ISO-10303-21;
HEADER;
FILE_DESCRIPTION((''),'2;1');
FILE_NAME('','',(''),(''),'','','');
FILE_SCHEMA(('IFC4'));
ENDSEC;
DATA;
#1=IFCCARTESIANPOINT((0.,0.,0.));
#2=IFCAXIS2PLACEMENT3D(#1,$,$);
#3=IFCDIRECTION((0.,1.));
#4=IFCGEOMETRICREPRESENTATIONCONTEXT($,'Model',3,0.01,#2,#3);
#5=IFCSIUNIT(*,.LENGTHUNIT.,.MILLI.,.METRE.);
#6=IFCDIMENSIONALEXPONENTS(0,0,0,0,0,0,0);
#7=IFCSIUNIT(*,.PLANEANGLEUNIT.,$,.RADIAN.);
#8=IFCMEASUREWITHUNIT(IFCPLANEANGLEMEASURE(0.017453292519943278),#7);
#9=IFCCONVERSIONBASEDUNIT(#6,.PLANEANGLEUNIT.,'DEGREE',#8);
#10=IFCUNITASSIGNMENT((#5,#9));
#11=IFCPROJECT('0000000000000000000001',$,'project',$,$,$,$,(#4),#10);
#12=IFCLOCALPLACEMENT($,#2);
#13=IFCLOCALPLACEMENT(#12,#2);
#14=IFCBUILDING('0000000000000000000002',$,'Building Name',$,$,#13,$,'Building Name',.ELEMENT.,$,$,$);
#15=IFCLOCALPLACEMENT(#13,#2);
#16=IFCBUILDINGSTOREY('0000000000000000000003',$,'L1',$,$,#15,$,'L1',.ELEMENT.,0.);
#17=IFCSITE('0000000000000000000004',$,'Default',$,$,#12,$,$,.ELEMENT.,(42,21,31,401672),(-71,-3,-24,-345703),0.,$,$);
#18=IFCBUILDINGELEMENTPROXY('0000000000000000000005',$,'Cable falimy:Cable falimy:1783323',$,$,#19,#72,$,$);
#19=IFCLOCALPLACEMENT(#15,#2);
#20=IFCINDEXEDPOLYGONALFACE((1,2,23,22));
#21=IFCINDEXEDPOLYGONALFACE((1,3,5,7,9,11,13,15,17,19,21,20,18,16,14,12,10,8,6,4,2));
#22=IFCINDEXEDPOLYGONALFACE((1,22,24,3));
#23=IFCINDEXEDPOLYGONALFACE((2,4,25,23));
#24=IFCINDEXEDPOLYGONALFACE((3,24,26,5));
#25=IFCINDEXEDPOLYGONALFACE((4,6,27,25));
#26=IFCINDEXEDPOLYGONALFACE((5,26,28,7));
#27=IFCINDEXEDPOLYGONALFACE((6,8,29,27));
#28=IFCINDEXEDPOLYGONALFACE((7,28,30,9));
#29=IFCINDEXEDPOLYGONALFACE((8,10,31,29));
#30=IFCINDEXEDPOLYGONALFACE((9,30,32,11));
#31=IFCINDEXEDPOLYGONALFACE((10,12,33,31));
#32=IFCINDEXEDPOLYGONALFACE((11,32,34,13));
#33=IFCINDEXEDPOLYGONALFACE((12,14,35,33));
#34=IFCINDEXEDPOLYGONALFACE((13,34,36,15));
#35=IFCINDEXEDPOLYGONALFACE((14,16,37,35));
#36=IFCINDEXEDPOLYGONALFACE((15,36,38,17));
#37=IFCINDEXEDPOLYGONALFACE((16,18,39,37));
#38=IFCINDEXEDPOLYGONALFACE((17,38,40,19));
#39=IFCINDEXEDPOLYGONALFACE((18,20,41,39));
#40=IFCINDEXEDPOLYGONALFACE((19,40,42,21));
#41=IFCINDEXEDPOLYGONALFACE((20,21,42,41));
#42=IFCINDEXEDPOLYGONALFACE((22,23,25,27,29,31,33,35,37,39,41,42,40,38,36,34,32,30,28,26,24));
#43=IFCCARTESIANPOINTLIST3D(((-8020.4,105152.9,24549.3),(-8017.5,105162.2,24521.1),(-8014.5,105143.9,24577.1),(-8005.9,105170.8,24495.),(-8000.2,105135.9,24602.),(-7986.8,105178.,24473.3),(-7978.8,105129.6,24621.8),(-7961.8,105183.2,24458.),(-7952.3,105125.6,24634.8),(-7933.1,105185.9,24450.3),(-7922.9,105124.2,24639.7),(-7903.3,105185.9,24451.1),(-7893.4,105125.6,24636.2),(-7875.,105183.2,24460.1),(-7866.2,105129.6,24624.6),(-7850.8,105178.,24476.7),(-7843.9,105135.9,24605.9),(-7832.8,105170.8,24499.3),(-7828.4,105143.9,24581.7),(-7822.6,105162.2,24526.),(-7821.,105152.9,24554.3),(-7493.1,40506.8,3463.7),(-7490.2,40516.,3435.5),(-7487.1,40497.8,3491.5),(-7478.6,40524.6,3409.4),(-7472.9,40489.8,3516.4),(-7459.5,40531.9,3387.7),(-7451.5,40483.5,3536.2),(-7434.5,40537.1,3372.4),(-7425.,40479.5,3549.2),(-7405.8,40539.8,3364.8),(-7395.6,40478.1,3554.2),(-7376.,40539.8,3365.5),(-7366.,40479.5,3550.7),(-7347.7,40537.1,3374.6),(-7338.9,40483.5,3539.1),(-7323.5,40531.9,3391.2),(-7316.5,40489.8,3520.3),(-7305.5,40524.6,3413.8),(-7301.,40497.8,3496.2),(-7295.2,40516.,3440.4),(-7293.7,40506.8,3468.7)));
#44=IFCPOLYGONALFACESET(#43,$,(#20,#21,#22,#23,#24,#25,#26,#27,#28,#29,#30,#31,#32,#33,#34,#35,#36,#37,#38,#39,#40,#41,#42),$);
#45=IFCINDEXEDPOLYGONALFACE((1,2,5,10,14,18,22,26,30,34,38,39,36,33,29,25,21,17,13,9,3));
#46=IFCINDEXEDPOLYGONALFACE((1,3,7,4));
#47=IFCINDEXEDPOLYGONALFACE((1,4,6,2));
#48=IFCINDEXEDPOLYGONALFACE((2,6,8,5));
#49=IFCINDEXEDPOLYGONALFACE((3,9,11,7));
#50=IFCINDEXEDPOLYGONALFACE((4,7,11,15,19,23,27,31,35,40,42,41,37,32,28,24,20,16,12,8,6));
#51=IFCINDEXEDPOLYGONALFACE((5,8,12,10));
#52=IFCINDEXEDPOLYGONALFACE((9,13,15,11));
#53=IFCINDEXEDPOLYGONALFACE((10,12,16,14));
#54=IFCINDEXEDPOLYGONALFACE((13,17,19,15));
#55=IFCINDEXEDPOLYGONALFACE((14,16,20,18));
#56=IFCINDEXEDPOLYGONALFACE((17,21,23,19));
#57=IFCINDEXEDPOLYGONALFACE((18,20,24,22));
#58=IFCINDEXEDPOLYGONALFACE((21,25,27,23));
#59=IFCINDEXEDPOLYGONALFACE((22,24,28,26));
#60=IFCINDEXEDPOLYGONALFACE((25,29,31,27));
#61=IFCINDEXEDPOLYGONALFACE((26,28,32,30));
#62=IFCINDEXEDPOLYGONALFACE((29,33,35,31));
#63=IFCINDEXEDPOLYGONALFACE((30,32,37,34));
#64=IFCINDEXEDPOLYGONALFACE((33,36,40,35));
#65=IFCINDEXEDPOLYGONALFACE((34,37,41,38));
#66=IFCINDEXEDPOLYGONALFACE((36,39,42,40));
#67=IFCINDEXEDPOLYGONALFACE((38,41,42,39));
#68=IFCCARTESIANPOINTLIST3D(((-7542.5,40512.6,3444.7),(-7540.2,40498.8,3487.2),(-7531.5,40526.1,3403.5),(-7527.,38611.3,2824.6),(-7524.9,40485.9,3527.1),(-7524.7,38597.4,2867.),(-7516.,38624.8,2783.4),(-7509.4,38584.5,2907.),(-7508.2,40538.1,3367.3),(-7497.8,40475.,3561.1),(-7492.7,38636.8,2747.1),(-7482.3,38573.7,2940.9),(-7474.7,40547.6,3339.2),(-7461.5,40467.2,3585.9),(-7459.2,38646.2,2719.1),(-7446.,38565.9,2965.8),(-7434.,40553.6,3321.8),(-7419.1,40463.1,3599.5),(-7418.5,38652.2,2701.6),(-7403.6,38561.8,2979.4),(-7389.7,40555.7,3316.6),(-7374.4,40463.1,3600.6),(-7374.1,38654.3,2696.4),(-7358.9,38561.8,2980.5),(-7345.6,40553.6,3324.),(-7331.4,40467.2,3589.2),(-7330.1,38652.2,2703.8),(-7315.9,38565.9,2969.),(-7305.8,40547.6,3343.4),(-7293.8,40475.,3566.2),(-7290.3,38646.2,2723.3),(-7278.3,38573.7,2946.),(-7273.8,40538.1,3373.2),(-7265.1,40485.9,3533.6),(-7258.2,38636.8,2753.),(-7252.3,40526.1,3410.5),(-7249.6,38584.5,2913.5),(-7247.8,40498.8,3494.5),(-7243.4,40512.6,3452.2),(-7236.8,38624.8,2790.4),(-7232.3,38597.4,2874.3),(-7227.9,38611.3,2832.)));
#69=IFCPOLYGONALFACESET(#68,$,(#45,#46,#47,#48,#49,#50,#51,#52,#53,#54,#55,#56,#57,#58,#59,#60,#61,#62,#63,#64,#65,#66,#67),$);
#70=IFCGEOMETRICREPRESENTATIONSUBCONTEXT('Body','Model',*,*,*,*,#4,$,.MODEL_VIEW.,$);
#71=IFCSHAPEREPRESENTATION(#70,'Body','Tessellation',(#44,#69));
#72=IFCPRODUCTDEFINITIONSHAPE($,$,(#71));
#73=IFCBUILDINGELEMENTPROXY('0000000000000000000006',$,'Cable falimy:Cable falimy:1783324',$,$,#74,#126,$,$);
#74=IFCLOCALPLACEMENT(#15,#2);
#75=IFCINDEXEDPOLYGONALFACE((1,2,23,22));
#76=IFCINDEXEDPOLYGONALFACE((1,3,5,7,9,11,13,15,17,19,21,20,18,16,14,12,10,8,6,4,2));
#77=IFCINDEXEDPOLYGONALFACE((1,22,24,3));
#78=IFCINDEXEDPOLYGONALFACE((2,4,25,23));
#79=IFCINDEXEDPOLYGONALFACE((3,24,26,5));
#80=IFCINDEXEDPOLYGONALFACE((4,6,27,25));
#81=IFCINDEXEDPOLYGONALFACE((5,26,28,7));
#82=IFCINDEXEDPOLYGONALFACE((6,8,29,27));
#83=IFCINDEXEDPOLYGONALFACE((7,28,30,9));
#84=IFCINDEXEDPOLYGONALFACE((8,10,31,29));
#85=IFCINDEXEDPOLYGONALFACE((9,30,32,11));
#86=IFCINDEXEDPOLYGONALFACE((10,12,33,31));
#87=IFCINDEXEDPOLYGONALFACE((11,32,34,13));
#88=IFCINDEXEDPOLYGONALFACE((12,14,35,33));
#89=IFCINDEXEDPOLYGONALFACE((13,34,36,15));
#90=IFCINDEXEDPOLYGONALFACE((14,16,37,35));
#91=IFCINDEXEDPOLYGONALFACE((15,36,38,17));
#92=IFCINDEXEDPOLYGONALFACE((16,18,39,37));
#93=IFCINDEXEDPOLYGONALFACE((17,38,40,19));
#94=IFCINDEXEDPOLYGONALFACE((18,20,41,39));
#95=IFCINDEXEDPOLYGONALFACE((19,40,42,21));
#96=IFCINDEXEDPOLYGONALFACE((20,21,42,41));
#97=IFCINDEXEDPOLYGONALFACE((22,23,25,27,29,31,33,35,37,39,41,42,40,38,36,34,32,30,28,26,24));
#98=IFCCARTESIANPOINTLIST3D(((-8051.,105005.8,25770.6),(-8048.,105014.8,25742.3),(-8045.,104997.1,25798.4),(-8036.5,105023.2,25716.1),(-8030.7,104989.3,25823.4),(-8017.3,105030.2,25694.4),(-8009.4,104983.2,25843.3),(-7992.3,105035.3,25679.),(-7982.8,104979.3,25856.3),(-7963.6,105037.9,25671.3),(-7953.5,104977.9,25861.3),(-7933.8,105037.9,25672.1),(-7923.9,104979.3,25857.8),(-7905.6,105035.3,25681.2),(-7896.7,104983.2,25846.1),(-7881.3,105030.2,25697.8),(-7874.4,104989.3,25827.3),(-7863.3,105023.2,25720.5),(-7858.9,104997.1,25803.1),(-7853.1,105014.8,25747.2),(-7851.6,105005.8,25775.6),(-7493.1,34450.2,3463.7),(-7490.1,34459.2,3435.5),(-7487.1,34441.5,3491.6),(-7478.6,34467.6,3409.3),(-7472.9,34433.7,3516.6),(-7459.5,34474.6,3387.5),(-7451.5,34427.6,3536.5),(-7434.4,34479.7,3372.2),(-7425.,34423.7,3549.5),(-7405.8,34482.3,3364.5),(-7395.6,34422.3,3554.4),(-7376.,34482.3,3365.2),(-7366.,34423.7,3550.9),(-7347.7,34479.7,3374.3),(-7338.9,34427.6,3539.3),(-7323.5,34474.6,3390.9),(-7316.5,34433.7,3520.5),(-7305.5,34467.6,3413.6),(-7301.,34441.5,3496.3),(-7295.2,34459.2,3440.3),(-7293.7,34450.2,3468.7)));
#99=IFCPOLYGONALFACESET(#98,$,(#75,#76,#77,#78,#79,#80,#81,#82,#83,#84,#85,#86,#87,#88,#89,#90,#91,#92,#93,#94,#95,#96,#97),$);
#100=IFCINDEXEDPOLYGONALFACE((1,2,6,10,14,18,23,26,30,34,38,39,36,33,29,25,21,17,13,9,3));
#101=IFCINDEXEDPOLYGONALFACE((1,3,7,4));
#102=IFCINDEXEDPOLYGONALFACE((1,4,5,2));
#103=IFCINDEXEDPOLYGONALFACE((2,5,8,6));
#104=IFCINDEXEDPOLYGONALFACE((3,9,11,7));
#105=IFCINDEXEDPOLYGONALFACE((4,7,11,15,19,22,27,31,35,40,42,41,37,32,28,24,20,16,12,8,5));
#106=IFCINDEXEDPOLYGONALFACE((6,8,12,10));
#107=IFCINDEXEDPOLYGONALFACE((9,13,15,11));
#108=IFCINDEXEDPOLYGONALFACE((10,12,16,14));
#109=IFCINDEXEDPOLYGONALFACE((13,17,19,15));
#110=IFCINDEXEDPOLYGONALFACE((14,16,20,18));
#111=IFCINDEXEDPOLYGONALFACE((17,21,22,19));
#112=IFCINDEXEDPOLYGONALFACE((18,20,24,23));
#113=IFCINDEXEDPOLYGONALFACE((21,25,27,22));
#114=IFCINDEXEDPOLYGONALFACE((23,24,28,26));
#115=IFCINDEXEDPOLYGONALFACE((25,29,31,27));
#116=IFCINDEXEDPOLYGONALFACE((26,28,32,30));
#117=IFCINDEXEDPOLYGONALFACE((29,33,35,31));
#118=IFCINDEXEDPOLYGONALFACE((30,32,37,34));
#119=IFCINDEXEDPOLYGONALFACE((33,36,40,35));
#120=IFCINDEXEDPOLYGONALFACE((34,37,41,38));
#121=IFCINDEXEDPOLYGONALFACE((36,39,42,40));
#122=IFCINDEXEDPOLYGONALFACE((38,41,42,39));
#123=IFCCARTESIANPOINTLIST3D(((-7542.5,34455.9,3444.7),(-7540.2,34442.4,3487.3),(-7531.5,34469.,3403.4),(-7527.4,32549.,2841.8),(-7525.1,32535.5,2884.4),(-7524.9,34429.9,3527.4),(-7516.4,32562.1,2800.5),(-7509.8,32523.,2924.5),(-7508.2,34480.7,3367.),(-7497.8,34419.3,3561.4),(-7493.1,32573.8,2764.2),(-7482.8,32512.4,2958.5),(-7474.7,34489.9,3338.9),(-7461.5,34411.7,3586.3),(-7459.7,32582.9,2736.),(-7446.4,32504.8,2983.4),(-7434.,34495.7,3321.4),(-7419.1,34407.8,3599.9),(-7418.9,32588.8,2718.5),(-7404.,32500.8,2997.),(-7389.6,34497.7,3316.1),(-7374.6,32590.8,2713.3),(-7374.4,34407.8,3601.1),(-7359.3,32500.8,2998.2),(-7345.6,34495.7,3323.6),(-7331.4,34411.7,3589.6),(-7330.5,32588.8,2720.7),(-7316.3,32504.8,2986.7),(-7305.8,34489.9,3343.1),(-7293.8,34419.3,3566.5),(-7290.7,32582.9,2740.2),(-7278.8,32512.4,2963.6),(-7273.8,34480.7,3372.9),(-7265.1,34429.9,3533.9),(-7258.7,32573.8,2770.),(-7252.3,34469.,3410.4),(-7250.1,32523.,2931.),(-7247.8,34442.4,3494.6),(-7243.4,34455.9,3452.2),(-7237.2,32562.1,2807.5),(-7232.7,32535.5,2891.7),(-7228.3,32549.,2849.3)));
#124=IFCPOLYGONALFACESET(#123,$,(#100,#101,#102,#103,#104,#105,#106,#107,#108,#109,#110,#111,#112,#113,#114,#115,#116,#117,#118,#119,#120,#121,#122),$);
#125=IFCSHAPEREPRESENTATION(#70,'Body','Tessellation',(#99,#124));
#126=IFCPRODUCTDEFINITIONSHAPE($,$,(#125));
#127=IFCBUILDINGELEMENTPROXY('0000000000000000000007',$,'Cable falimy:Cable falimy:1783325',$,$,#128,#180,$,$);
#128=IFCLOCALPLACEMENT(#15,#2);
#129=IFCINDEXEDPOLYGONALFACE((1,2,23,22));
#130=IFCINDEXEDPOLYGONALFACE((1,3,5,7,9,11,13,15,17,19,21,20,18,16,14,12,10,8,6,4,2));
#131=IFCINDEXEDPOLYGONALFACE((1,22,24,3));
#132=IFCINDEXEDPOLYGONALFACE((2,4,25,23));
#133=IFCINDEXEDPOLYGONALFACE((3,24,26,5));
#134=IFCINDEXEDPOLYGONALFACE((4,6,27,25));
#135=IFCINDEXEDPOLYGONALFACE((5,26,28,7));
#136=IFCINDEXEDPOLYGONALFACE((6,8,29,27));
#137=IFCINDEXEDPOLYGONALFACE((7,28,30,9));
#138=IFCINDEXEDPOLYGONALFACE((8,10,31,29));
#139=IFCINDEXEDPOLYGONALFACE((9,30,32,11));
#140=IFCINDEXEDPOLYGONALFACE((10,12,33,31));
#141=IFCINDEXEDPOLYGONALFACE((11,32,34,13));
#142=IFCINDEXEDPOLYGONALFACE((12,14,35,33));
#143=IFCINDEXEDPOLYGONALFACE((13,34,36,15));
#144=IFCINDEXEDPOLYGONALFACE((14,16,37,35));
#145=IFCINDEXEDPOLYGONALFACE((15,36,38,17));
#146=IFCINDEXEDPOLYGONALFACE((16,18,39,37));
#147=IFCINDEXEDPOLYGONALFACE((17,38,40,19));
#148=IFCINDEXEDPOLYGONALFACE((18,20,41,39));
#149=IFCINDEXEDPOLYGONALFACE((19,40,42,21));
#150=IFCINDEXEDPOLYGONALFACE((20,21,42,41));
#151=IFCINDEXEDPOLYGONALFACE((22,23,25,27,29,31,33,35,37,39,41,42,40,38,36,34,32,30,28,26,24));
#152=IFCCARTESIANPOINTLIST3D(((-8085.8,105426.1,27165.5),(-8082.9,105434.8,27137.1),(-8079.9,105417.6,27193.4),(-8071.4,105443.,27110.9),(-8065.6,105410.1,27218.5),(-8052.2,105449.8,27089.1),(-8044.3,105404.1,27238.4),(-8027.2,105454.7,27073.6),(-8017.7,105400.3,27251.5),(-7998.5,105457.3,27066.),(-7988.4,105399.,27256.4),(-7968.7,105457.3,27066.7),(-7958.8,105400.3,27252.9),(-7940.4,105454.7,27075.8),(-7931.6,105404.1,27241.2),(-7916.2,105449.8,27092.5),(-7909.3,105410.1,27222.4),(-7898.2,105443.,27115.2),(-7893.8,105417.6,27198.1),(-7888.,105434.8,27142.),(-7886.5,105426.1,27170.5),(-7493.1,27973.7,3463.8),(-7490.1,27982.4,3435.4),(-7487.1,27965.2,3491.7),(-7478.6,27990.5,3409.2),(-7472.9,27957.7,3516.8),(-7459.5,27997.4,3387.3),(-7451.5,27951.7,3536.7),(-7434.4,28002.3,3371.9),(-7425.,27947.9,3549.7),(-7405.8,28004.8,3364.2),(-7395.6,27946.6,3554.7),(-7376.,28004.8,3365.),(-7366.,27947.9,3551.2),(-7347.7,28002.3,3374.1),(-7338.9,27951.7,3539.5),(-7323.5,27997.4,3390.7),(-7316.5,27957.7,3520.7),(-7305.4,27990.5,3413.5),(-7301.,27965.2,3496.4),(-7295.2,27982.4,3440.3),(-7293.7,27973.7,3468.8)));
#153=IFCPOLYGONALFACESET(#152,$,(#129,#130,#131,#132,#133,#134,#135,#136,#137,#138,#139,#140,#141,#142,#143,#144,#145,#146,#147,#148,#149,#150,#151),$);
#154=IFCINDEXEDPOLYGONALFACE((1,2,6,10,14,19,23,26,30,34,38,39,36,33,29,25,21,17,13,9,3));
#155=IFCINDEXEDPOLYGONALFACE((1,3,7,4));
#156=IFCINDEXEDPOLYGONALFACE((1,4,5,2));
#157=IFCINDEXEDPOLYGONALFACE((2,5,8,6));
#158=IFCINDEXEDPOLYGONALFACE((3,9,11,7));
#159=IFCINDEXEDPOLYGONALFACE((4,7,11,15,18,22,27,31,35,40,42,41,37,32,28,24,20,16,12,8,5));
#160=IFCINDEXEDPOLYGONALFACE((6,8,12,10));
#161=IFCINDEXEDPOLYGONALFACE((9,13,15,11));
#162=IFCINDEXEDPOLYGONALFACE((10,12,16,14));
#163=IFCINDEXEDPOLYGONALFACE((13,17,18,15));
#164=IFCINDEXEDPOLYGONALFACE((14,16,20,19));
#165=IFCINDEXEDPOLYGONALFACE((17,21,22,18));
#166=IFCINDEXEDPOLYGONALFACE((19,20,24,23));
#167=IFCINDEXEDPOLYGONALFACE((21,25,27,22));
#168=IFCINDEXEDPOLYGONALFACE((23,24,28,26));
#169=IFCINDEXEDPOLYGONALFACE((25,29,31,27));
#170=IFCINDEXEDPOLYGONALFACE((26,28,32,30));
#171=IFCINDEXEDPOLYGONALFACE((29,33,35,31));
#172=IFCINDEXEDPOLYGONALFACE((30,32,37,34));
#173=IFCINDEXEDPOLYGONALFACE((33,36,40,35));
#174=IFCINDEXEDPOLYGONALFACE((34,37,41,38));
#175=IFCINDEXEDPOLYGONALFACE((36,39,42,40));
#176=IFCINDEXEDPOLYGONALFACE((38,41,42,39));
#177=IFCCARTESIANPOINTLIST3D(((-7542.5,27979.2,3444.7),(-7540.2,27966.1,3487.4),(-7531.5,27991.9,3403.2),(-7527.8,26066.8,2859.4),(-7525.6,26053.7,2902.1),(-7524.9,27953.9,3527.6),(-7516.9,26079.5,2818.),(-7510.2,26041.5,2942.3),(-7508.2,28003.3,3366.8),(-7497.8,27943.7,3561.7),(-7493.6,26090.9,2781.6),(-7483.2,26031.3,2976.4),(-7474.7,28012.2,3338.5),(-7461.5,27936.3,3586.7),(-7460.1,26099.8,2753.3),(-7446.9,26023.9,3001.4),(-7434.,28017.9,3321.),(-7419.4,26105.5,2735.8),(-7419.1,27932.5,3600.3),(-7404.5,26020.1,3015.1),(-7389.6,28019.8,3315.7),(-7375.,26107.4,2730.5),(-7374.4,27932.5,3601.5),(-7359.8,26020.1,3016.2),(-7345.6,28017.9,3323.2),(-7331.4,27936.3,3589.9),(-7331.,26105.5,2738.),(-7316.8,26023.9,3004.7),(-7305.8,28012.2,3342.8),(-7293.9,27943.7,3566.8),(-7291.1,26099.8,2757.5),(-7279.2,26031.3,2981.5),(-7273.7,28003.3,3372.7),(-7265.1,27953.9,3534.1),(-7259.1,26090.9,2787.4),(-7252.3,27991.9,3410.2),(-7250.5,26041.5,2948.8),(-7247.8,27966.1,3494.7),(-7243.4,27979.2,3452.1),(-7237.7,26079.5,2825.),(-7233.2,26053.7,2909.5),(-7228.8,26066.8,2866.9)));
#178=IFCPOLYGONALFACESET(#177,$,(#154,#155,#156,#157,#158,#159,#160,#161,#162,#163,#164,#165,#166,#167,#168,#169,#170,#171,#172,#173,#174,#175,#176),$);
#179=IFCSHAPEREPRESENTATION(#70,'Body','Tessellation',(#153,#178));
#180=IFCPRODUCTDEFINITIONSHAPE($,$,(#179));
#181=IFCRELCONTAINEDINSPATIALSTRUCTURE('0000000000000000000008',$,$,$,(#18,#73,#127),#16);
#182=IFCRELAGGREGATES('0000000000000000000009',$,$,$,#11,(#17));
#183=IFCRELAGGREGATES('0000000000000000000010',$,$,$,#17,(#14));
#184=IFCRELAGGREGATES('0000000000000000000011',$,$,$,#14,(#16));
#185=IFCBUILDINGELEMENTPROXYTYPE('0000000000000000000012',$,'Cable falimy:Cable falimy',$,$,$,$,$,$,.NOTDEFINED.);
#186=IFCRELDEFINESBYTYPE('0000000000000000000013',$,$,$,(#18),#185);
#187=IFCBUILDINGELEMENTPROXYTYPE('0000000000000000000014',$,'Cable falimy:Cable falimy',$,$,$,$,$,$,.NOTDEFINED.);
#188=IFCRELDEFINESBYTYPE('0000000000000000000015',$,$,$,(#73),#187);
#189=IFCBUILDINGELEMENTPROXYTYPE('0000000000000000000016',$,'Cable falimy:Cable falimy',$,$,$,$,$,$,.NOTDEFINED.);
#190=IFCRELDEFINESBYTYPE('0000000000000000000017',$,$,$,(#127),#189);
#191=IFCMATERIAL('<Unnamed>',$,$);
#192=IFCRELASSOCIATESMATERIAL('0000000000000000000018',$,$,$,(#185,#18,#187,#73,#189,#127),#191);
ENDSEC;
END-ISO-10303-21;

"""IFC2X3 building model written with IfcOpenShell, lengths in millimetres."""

from ifc_helpers import new_model, entity, si_unit, converted_unit, direction, frame, frame_2d, origin, place, context, subcontext, project, spatial, circle, extrude, source, transform, mapped, material, type_object, type_shapes, element, save


model = new_model("IFC2X3")

# Units and contexts
model_context = context("Model", 3, precision=0.01, world=origin(), true_north=direction((0.0, 1.0)))
body_context = subcontext(model_context, "Body", "Model", "MODEL_VIEW")
ifc_project = project(units=[si_unit("LENGTHUNIT", "METRE", prefix="MILLI"), converted_unit("PLANEANGLEUNIT", "DEGREE", entity("IfcPlaneAngleMeasure", 0.017453292519943278), si_unit("PLANEANGLEUNIT", "RADIAN"), dimensions=[0, 0, 0, 0, 0, 0, 0])], contexts=[model_context])

# Site, building, storey
site_placement = place(None, origin())
site = spatial("IfcSite", under=ifc_project, at=site_placement, Name="Default", CompositionType="ELEMENT", RefLatitude=(42, 21, 31, 401672), RefLongitude=(-71, -3, -24, -345703), RefElevation=0.0)
building_placement = place(site_placement, origin())
building = spatial("IfcBuilding", under=site, at=building_placement, Name="Building Name", LongName="Building Name", CompositionType="ELEMENT")
storey_placement = place(building_placement, origin())
storey = spatial("IfcBuildingStorey", under=building, at=storey_placement, Name="L1", LongName="L1", CompositionType="ELEMENT", Elevation=0.0)

# Shared definitions
ifc_material = material(Name="<Unnamed>")

# Building element proxies
building_element_proxy_type_1 = type_object("IfcBuildingElementProxyType", Name="Cable falimy:Cable falimy", PredefinedType="NOTDEFINED", material=ifc_material)
shared_shape_1 = source(origin(), body_context, "Body", "SweptSolid", [
    extrude(circle(Radius=100.0, at=frame_2d((0.0, 0.0), x_axis=(1.0, 0.0))), frame((0.0, 0.0, 0.0), z_axis=(0.950678, 0.0, 0.310179), x_axis=(-0.310179, 0.0, 0.950678)), (0.0, 0.0, 1.0), 68000.0),
    extrude(circle(Radius=150.0, at=frame_2d((0.0, 0.0), x_axis=(1.0, 0.0))), frame((-1901.4, 0.0, -620.4), z_axis=(0.950678, 0.0, 0.310179), x_axis=(0.310179, 0.0, -0.950678)), (0.0, 0.0, 1.0), 2000.0),
])
type_shapes(building_element_proxy_type_1, [shared_shape_1])
proxy_1_placement = place(storey_placement, frame((-7393.2, 40509.1, 3459.1), z_axis=(-0.025001, 0.0, 0.999687), x_axis=(0.0, 1.0, 0.0)))
element("IfcBuildingElementProxy", 1, at=proxy_1_placement, inside=storey, type_object=building_element_proxy_type_1, material=ifc_material, Name="Cable falimy:Cable falimy:1783323", context=body_context, shape_type="MappedRepresentation", body=[
    mapped(shared_shape_1, transform((0.0, 0.0, 0.0), scale=1.0)),
])
building_element_proxy_type_2 = type_object("IfcBuildingElementProxyType", Name="Cable falimy:Cable falimy", PredefinedType="NOTDEFINED", material=ifc_material)
shared_shape_2 = source(origin(), body_context, "Body", "SweptSolid", [
    extrude(circle(Radius=100.0, at=frame_2d((0.0, 0.0), x_axis=(1.0, 0.0))), frame((0.0, 0.0, 0.0), z_axis=(0.953454, 0.0, 0.301538), x_axis=(-0.301538, 0.0, 0.953454)), (0.0, 0.0, 1.0), 74000.0),
    extrude(circle(Radius=150.0, at=frame_2d((0.0, 0.0), x_axis=(1.0, 0.0))), frame((-1906.9, 0.0, -603.1), z_axis=(0.953454, 0.0, 0.301538), x_axis=(0.301538, 0.0, -0.953454)), (0.0, 0.0, 1.0), 2000.0),
])
type_shapes(building_element_proxy_type_2, [shared_shape_2])
proxy_2_placement = place(storey_placement, frame((-7393.2, 34452.5, 3459.1), z_axis=(-0.025001, 0.0, 0.999687), x_axis=(0.0, 1.0, 0.0)))
element("IfcBuildingElementProxy", 2, at=proxy_2_placement, inside=storey, type_object=building_element_proxy_type_2, material=ifc_material, Name="Cable falimy:Cable falimy:1783324", context=body_context, shape_type="MappedRepresentation", body=[
    mapped(shared_shape_2, transform((0.0, 0.0, 0.0), scale=1.0)),
])
building_element_proxy_type_3 = type_object("IfcBuildingElementProxyType", Name="Cable falimy:Cable falimy", PredefinedType="NOTDEFINED", material=ifc_material)
shared_shape_3 = source(origin(), body_context, "Body", "SweptSolid", [
    extrude(circle(Radius=100.0, at=frame_2d((0.0, 0.0), x_axis=(1.0, 0.0))), frame((0.0, 0.0, 0.0), z_axis=(0.956203, 0.0, 0.292706), x_axis=(-0.292706, 0.0, 0.956203)), (0.0, 0.0, 1.0), 81000.0),
    extrude(circle(Radius=150.0, at=frame_2d((0.0, 0.0), x_axis=(1.0, 0.0))), frame((-1912.4, 0.0, -585.4), z_axis=(0.956203, 0.0, 0.292706), x_axis=(0.292706, 0.0, -0.956203)), (0.0, 0.0, 1.0), 2000.0),
])
type_shapes(building_element_proxy_type_3, [shared_shape_3])
proxy_3_placement = place(storey_placement, frame((-7393.2, 27975.9, 3459.1), z_axis=(-0.025001, 0.0, 0.999687), x_axis=(0.0, 1.0, 0.0)))
element("IfcBuildingElementProxy", 3, at=proxy_3_placement, inside=storey, type_object=building_element_proxy_type_3, material=ifc_material, Name="Cable falimy:Cable falimy:1783325", context=body_context, shape_type="MappedRepresentation", body=[
    mapped(shared_shape_3, transform((0.0, 0.0, 0.0), scale=1.0)),
])

save(model, "model.ifc")
